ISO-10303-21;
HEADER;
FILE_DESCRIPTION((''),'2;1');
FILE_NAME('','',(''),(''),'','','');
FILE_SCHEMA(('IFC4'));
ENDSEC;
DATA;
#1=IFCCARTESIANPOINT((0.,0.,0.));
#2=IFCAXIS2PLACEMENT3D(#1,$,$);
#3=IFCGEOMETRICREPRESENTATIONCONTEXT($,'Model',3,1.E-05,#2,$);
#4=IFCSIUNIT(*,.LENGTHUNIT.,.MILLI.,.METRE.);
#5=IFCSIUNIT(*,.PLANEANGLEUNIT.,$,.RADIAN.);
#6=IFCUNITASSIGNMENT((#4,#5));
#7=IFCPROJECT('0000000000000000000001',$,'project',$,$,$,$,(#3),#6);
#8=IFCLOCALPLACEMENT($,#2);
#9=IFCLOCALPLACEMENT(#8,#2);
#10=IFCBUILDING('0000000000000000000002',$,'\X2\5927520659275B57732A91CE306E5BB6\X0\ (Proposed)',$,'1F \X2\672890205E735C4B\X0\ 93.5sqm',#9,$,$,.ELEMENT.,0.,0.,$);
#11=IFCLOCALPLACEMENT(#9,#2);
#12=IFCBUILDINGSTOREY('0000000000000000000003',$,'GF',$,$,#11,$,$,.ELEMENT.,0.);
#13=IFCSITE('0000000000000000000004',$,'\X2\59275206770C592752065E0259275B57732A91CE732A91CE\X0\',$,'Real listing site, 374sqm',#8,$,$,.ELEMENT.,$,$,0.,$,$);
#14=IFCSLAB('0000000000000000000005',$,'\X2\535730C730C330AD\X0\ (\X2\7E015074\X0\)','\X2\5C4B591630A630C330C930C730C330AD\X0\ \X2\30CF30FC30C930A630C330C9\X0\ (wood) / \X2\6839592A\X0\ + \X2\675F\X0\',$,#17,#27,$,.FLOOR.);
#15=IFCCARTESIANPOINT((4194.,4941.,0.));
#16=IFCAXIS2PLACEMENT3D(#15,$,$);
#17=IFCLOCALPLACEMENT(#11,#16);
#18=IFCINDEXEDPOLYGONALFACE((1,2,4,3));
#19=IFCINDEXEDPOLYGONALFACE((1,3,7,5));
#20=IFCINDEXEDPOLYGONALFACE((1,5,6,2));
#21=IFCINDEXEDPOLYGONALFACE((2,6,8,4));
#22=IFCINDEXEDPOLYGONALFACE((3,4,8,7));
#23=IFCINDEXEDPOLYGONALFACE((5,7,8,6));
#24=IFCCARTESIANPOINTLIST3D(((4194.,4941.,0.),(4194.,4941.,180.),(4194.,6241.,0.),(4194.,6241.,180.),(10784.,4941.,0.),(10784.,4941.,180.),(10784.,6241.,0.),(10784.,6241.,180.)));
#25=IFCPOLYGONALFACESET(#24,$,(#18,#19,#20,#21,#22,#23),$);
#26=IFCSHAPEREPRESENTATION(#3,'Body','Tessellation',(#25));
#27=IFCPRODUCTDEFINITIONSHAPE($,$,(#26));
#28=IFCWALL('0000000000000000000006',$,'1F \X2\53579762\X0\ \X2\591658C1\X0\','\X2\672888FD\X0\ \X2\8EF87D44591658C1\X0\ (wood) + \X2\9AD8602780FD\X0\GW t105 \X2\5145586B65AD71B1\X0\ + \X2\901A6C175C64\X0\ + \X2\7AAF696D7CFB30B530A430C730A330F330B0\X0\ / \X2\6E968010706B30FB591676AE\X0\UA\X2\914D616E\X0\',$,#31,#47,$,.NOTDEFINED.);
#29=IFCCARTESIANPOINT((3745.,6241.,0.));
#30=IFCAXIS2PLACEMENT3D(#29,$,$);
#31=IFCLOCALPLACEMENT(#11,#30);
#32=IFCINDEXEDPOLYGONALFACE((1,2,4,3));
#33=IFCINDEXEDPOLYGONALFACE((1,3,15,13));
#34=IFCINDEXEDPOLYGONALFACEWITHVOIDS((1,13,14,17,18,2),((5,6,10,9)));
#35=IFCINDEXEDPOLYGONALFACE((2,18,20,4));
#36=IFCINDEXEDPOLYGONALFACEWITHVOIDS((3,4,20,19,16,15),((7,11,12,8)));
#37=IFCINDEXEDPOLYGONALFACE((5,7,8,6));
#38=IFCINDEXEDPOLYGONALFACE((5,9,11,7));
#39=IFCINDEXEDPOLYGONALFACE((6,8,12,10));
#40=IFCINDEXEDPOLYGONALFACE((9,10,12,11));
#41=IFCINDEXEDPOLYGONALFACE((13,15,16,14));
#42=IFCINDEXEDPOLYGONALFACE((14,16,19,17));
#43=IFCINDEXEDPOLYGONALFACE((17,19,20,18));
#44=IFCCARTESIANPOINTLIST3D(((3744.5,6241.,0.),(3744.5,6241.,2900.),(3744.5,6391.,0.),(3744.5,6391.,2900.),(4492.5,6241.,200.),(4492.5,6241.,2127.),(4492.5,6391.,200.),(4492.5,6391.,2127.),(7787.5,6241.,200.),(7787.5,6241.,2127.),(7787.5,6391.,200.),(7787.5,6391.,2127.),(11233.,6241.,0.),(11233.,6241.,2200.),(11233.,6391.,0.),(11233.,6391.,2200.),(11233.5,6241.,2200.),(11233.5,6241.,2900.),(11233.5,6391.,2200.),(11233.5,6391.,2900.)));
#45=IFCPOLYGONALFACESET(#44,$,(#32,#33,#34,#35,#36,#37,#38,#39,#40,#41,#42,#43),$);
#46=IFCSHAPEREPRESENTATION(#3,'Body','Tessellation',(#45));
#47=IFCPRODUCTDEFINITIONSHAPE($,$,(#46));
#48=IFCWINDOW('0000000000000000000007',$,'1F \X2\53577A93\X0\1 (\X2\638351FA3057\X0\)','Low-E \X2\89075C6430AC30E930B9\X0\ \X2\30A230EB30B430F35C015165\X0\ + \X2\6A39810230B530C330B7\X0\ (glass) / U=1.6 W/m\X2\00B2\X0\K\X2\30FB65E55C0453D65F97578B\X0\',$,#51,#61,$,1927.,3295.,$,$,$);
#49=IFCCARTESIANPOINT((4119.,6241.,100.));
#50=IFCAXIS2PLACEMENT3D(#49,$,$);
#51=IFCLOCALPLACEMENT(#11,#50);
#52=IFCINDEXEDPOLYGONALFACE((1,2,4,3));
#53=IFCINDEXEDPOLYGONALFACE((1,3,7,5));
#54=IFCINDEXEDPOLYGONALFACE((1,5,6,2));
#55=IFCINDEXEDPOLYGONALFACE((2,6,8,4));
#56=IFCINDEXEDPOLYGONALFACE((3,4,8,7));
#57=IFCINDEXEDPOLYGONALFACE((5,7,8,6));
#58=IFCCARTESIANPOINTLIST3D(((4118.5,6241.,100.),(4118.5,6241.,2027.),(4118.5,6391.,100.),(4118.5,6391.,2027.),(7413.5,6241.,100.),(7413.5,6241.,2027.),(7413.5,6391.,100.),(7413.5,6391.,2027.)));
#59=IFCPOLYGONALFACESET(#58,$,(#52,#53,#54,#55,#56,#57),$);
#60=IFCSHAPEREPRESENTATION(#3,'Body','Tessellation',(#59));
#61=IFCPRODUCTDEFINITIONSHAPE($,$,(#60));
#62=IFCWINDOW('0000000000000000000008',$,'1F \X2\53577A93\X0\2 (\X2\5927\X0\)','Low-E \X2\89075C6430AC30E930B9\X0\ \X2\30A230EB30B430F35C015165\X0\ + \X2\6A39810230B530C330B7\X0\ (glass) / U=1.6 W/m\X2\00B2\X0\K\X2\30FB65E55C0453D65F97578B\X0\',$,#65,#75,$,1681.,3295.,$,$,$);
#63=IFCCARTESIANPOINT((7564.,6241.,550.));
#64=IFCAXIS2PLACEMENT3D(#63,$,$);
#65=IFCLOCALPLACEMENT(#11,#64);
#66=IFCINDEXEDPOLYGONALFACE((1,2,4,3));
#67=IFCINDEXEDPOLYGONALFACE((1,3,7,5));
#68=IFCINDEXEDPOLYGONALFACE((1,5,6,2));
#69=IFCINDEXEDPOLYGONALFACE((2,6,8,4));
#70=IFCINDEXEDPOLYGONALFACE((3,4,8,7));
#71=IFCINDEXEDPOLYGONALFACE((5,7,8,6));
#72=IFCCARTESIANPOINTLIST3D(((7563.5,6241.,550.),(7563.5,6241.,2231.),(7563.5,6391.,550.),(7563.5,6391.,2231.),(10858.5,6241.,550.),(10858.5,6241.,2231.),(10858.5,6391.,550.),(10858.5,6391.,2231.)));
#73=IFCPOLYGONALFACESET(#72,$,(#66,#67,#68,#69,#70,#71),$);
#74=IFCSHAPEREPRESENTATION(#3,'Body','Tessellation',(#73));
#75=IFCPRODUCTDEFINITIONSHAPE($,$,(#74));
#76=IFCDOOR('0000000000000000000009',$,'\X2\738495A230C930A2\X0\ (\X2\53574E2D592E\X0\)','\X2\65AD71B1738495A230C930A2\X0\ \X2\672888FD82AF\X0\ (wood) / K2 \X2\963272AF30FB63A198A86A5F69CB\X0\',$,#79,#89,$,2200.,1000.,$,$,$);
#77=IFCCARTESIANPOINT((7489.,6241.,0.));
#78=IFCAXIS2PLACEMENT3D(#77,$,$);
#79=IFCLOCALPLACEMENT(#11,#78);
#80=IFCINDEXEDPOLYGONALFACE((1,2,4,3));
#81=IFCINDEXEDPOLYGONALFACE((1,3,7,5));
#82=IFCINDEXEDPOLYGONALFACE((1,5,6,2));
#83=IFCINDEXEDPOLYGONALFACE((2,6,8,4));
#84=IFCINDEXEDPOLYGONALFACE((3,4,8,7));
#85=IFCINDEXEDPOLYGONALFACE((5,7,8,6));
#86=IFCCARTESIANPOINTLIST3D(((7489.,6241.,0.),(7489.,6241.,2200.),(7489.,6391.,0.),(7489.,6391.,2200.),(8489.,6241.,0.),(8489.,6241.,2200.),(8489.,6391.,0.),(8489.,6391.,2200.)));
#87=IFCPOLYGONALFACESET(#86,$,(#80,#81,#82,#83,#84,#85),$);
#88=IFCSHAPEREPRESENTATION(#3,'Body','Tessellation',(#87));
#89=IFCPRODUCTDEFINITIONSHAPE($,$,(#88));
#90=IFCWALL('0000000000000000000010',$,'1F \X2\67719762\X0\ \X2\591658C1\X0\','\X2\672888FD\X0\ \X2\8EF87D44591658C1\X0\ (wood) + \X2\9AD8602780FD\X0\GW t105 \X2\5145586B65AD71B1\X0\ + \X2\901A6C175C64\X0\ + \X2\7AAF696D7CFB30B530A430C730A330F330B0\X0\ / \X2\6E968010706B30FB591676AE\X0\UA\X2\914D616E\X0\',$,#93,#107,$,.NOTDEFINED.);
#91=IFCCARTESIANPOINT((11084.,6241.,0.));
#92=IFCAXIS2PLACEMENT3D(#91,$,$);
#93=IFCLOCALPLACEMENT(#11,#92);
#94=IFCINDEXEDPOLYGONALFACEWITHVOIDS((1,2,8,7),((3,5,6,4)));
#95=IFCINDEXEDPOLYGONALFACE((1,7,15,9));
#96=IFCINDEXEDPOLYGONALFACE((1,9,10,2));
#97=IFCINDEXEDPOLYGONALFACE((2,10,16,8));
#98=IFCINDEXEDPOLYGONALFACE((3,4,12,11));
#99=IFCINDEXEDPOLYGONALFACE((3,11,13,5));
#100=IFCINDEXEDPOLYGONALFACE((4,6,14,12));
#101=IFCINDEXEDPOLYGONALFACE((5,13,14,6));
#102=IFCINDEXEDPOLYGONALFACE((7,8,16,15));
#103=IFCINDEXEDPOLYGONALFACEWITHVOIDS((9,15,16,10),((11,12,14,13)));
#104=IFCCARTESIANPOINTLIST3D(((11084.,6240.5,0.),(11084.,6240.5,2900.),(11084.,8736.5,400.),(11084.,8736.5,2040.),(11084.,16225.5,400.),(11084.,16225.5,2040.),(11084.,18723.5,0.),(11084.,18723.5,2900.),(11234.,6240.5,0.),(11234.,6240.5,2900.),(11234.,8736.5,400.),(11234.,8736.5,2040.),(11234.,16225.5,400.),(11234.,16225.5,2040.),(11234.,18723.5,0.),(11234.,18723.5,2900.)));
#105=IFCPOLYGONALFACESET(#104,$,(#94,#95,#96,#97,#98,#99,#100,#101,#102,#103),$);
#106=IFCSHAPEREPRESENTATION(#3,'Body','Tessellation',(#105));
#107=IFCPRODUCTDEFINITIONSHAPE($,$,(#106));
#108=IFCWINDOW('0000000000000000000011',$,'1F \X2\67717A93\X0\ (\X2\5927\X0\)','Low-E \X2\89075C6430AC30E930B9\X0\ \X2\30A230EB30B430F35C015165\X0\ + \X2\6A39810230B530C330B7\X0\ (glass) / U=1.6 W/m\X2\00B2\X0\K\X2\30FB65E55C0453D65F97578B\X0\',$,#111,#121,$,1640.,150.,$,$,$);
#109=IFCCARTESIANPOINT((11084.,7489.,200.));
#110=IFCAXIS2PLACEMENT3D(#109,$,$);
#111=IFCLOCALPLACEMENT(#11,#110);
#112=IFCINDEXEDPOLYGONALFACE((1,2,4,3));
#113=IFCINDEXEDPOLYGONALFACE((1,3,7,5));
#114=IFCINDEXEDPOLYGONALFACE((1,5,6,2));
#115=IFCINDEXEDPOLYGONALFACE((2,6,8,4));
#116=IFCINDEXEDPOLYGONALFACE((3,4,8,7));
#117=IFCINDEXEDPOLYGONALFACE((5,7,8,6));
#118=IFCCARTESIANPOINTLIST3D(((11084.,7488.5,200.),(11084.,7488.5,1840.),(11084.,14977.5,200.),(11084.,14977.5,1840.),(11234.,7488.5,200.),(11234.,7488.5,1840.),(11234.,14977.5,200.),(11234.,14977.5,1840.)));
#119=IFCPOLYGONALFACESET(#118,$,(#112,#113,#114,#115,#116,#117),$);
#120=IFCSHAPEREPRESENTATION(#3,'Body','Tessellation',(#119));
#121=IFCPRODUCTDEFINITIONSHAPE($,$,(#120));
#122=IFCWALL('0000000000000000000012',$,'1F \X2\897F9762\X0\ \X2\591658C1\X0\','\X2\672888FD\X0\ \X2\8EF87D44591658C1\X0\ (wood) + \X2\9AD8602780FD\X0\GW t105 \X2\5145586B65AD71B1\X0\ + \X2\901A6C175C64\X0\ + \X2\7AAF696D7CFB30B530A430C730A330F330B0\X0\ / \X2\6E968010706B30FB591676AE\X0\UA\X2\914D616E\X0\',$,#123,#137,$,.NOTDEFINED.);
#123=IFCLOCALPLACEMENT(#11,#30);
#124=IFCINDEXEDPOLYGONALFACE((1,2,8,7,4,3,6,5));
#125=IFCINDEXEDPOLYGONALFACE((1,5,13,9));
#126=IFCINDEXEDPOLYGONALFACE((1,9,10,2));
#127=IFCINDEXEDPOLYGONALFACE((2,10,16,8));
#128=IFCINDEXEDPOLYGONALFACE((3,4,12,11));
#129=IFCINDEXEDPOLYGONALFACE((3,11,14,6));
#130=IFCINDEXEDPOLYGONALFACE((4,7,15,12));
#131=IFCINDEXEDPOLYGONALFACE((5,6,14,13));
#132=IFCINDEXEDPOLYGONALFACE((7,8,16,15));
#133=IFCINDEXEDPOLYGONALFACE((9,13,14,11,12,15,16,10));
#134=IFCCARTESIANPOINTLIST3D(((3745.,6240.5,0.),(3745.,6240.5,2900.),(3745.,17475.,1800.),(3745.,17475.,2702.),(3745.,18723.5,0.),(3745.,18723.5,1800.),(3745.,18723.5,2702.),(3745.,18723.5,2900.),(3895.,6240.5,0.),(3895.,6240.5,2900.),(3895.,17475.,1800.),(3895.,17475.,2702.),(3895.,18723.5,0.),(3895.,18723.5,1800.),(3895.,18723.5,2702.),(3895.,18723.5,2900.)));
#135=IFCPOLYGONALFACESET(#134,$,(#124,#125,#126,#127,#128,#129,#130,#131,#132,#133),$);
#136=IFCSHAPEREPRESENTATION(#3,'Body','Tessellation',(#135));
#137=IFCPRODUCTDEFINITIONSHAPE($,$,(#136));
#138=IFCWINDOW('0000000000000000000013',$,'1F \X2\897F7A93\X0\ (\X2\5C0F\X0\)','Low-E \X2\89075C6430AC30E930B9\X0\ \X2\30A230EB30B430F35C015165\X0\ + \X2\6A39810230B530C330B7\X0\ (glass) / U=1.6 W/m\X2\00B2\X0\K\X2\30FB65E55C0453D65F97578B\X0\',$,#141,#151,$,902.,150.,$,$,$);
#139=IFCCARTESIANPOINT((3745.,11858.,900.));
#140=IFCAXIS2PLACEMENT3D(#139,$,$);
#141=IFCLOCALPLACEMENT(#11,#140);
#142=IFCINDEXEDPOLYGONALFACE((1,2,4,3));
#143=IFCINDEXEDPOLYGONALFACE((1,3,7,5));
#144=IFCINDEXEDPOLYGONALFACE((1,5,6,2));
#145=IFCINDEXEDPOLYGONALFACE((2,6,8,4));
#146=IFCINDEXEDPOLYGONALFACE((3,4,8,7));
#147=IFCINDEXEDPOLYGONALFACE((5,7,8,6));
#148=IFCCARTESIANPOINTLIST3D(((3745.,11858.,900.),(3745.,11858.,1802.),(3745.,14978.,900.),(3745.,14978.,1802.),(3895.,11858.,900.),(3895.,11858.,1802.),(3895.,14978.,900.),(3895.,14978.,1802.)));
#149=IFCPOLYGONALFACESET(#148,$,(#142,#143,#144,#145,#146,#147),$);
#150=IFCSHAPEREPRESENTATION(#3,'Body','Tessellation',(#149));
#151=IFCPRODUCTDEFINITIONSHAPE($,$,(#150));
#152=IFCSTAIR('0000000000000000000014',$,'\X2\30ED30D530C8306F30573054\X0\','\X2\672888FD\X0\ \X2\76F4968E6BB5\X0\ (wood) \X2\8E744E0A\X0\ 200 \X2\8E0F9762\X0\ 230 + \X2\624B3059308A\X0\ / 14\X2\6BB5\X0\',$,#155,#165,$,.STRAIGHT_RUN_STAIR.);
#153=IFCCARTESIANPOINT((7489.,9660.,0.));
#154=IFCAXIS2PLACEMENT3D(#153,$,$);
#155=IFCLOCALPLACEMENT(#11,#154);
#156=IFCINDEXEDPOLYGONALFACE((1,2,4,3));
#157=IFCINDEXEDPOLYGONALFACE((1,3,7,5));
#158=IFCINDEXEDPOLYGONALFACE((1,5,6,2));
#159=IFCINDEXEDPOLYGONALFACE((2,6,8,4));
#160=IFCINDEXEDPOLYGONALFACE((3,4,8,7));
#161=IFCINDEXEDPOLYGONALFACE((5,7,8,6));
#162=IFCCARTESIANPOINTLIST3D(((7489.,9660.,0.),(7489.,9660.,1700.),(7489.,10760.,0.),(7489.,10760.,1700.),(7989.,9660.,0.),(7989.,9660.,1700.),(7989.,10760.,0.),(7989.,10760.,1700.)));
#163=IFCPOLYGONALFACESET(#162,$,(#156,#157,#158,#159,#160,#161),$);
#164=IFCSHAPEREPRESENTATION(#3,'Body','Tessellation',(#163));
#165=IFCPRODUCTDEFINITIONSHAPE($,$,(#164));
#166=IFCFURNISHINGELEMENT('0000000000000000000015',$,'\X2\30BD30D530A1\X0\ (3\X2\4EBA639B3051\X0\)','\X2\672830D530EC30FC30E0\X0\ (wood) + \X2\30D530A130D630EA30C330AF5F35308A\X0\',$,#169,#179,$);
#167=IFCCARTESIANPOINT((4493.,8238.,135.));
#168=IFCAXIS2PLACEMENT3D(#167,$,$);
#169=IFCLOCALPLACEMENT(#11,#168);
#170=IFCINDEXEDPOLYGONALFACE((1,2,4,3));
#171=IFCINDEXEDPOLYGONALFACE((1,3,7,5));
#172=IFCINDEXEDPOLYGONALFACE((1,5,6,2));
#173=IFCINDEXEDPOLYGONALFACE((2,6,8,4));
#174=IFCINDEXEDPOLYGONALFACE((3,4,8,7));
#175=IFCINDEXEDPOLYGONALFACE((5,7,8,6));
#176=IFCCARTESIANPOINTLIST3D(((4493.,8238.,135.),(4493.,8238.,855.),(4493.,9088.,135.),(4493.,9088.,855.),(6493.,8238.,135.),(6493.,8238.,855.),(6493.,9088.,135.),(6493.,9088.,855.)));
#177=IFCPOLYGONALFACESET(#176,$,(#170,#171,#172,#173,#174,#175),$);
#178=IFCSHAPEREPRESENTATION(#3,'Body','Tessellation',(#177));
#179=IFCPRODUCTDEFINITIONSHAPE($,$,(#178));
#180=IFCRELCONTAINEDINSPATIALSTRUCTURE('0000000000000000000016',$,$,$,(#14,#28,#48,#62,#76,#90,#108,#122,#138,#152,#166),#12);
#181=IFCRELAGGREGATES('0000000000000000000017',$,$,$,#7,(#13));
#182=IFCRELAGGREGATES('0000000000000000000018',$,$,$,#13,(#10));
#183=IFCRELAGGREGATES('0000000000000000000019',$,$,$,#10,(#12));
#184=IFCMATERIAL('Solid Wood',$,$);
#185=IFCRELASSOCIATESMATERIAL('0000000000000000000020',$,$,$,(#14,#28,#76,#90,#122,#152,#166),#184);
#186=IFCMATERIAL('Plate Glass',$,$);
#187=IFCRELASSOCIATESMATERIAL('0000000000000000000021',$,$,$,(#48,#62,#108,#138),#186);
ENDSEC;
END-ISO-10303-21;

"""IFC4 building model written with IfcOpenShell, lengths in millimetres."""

from ifc_helpers import new_model, si_unit, frame, frame_2d, origin, place, context, project, spatial, rectangle, extrude, material, element, fill, save


model = new_model("IFC4")

# Units and contexts
model_context = context("Model", 3, precision=1e-05, world=origin())
ifc_project = project(units=[si_unit("LENGTHUNIT", "METRE", prefix="MILLI"), si_unit("PLANEANGLEUNIT", "RADIAN")], contexts=[model_context])

# Site, building, storey
site_placement = place(None, origin())
site = spatial("IfcSite", under=ifc_project, at=site_placement, Name="大分県大分市大字猪野猪野", ObjectType="Real listing site, 374sqm", CompositionType="ELEMENT", RefElevation=0.0)
building_placement = place(site_placement, origin())
building = spatial("IfcBuilding", under=site, at=building_placement, Name="大分大字猪野の家 (Proposed)", ObjectType="1F 木造平屋 93.5sqm", CompositionType="ELEMENT", ElevationOfRefHeight=0.0, ElevationOfTerrain=0.0)
storey_placement = place(building_placement, origin())
storey = spatial("IfcBuildingStorey", under=building, at=storey_placement, Name="GF", CompositionType="ELEMENT", Elevation=0.0)

# Slab
ifc_material_1 = material(Name="Solid Wood")
slab_1_placement = place(storey_placement, frame((4194.0, 4941.0, 0.0)))
element("IfcSlab", 1, at=slab_1_placement, inside=storey, material=ifc_material_1, Name="南デッキ (縁側)", Description="屋外ウッドデッキ ハードウッド (wood) / 根太 + 束", PredefinedType="FLOOR", context=model_context, shape_type="SweptSolid", body=[
    extrude(rectangle(XDim=6590.0, YDim=1300.0, at=frame_2d((3295.0, 650.0))), frame((4194.0, 4941.0, 0.0)), (0.0, 0.0, 1.0), 180.0),
])

# Wall, openings, windows, door
wall_1_placement = place(storey_placement, frame((3745.0, 6241.0, 0.0)))
wall_1 = element("IfcWall", 2, at=wall_1_placement, inside=storey, material=ifc_material_1, Name="1F 南面 外壁", Description="木製 軸組外壁 (wood) + 高性能GW t105 充填断熱 + 通気層 + 窯業系サイディング / 準耐火・外皮UA配慮", PredefinedType="NOTDEFINED", context=model_context, shape_type="SweptSolid", body=[
    extrude(rectangle(XDim=7489.0, YDim=150.0, at=frame_2d((3744.0, 75.0))), frame((3745.0, 6241.0, 0.0)), (0.0, 0.0, 1.0), 2900.0),
])
opening_1_placement = place(storey_placement, frame((4119.0, 6241.0, 100.0)))
opening_1 = element("IfcOpeningElement", 3, at=opening_1_placement, cuts=wall_1, PredefinedType="NOTDEFINED", context=model_context, shape_type="SweptSolid", body=[
    extrude(rectangle(XDim=3295.0, YDim=150.0, at=frame_2d((1647.0, 75.0))), frame((4119.0, 6241.0, 100.0)), (0.0, 0.0, 1.0), 1927.0),
])
opening_2_placement = place(storey_placement, frame((7564.0, 6241.0, 550.0)))
opening_2 = element("IfcOpeningElement", 4, at=opening_2_placement, cuts=wall_1, PredefinedType="NOTDEFINED", context=model_context, shape_type="SweptSolid", body=[
    extrude(rectangle(XDim=3295.0, YDim=150.0, at=frame_2d((1647.0, 75.0))), frame((7564.0, 6241.0, 550.0)), (0.0, 0.0, 1.0), 1681.0),
])
opening_3_placement = place(storey_placement, frame((7489.0, 6241.0, 0.0)))
opening_3 = element("IfcOpeningElement", 5, at=opening_3_placement, cuts=wall_1, PredefinedType="NOTDEFINED", context=model_context, shape_type="SweptSolid", body=[
    extrude(rectangle(XDim=1000.0, YDim=150.0, at=frame_2d((500.0, 75.0))), frame((7489.0, 6241.0, 0.0)), (0.0, 0.0, 1.0), 2200.0),
])
ifc_material_2 = material(Name="Plate Glass")
window_1_placement = place(storey_placement, frame((4119.0, 6241.0, 100.0)))
window_1 = element("IfcWindow", 6, at=window_1_placement, inside=storey, material=ifc_material_2, Name="1F 南窓1 (掃出し)", Description="Low-E 複層ガラス アルゴン封入 + 樹脂サッシ (glass) / U=1.6 W/m²K・日射取得型", OverallHeight=1927.0, OverallWidth=3295.0, context=model_context, shape_type="SweptSolid", body=[
    extrude(rectangle(XDim=3295.0, YDim=150.0, at=frame_2d((1647.0, 75.0))), frame((4119.0, 6241.0, 100.0)), (0.0, 0.0, 1.0), 1927.0),
])
fill(opening_1, window_1)
window_2_placement = place(storey_placement, frame((7564.0, 6241.0, 550.0)))
window_2 = element("IfcWindow", 7, at=window_2_placement, inside=storey, material=ifc_material_2, Name="1F 南窓2 (大)", Description="Low-E 複層ガラス アルゴン封入 + 樹脂サッシ (glass) / U=1.6 W/m²K・日射取得型", OverallHeight=1681.0, OverallWidth=3295.0, context=model_context, shape_type="SweptSolid", body=[
    extrude(rectangle(XDim=3295.0, YDim=150.0, at=frame_2d((1647.0, 75.0))), frame((7564.0, 6241.0, 550.0)), (0.0, 0.0, 1.0), 1681.0),
])
fill(opening_2, window_2)
door_placement = place(storey_placement, frame((7489.0, 6241.0, 0.0)))
door = element("IfcDoor", 8, at=door_placement, inside=storey, material=ifc_material_1, Name="玄関ドア (南中央)", Description="断熱玄関ドア 木製芯 (wood) / K2 防犯・採風機構", OverallHeight=2200.0, OverallWidth=1000.0, context=model_context, shape_type="SweptSolid", body=[
    extrude(rectangle(XDim=1000.0, YDim=150.0, at=frame_2d((500.0, 75.0))), frame((7489.0, 6241.0, 0.0)), (0.0, 0.0, 1.0), 2200.0),
])
fill(opening_3, door)

# Walls, openings, windows
wall_2_placement = place(storey_placement, frame((11084.0, 6241.0, 0.0)))
wall_2 = element("IfcWall", 9, at=wall_2_placement, inside=storey, material=ifc_material_1, Name="1F 東面 外壁", Description="木製 軸組外壁 (wood) + 高性能GW t105 充填断熱 + 通気層 + 窯業系サイディング / 準耐火・外皮UA配慮", PredefinedType="NOTDEFINED", context=model_context, shape_type="SweptSolid", body=[
    extrude(rectangle(XDim=150.0, YDim=12483.0, at=frame_2d((75.0, 6241.0))), frame((11084.0, 6241.0, 0.0)), (0.0, 0.0, 1.0), 2900.0),
])
opening_4_placement = place(storey_placement, frame((11084.0, 7489.0, 200.0)))
opening_4 = element("IfcOpeningElement", 10, at=opening_4_placement, cuts=wall_2, PredefinedType="NOTDEFINED", context=model_context, shape_type="SweptSolid", body=[
    extrude(rectangle(XDim=150.0, YDim=7489.0, at=frame_2d((75.0, 3744.0))), frame((11084.0, 7489.0, 200.0)), (0.0, 0.0, 1.0), 1640.0),
])
window_3_placement = place(storey_placement, frame((11084.0, 7489.0, 200.0)))
window_3 = element("IfcWindow", 11, at=window_3_placement, inside=storey, material=ifc_material_2, Name="1F 東窓 (大)", Description="Low-E 複層ガラス アルゴン封入 + 樹脂サッシ (glass) / U=1.6 W/m²K・日射取得型", OverallHeight=1640.0, OverallWidth=150.0, context=model_context, shape_type="SweptSolid", body=[
    extrude(rectangle(XDim=150.0, YDim=7489.0, at=frame_2d((75.0, 3744.0))), frame((11084.0, 7489.0, 200.0)), (0.0, 0.0, 1.0), 1640.0),
])
fill(opening_4, window_3)
wall_3_placement = place(storey_placement, frame((3745.0, 6241.0, 0.0)))
wall_3 = element("IfcWall", 12, at=wall_3_placement, inside=storey, material=ifc_material_1, Name="1F 西面 外壁", Description="木製 軸組外壁 (wood) + 高性能GW t105 充填断熱 + 通気層 + 窯業系サイディング / 準耐火・外皮UA配慮", PredefinedType="NOTDEFINED", context=model_context, shape_type="SweptSolid", body=[
    extrude(rectangle(XDim=150.0, YDim=12483.0, at=frame_2d((75.0, 6241.0))), frame((3745.0, 6241.0, 0.0)), (0.0, 0.0, 1.0), 2900.0),
])
opening_5_placement = place(storey_placement, frame((3745.0, 11858.0, 900.0)))
opening_5 = element("IfcOpeningElement", 13, at=opening_5_placement, cuts=wall_3, PredefinedType="NOTDEFINED", context=model_context, shape_type="SweptSolid", body=[
    extrude(rectangle(XDim=150.0, YDim=3120.0, at=frame_2d((75.0, 1560.0))), frame((3745.0, 11858.0, 900.0)), (0.0, 0.0, 1.0), 902.0),
])
window_4_placement = place(storey_placement, frame((3745.0, 11858.0, 900.0)))
window_4 = element("IfcWindow", 14, at=window_4_placement, inside=storey, material=ifc_material_2, Name="1F 西窓 (小)", Description="Low-E 複層ガラス アルゴン封入 + 樹脂サッシ (glass) / U=1.6 W/m²K・日射取得型", OverallHeight=902.0, OverallWidth=150.0, context=model_context, shape_type="SweptSolid", body=[
    extrude(rectangle(XDim=150.0, YDim=3120.0, at=frame_2d((75.0, 1560.0))), frame((3745.0, 11858.0, 900.0)), (0.0, 0.0, 1.0), 902.0),
])
fill(opening_5, window_4)

# Stair
stair_placement = place(storey_placement, frame((7489.0, 9660.0, 0.0)))
element("IfcStair", 15, at=stair_placement, inside=storey, material=ifc_material_1, Name="ロフトはしご", Description="木製 直階段 (wood) 蹴上 200 踏面 230 + 手すり / 14段", PredefinedType="STRAIGHT_RUN_STAIR", context=model_context, shape_type="SweptSolid", body=[
    extrude(rectangle(XDim=500.0, YDim=1100.0, at=frame_2d((250.0, 550.0))), frame((7489.0, 9660.0, 0.0)), (0.0, 0.0, 1.0), 1700.0),
])

# Furnishing element
furnishing_1_placement = place(storey_placement, frame((4493.0, 8238.0, 135.0)))
element("IfcFurnishingElement", 16, at=furnishing_1_placement, inside=storey, material=ifc_material_1, Name="ソファ (3人掛け)", Description="木フレーム (wood) + ファブリック張り", context=model_context, shape_type="SweptSolid", body=[
    extrude(rectangle(XDim=2000.0, YDim=850.0, at=frame_2d((1000.0, 425.0))), frame((4493.0, 8238.0, 135.0)), (0.0, 0.0, 1.0), 720.0),
])

save(model, "model.ifc")
